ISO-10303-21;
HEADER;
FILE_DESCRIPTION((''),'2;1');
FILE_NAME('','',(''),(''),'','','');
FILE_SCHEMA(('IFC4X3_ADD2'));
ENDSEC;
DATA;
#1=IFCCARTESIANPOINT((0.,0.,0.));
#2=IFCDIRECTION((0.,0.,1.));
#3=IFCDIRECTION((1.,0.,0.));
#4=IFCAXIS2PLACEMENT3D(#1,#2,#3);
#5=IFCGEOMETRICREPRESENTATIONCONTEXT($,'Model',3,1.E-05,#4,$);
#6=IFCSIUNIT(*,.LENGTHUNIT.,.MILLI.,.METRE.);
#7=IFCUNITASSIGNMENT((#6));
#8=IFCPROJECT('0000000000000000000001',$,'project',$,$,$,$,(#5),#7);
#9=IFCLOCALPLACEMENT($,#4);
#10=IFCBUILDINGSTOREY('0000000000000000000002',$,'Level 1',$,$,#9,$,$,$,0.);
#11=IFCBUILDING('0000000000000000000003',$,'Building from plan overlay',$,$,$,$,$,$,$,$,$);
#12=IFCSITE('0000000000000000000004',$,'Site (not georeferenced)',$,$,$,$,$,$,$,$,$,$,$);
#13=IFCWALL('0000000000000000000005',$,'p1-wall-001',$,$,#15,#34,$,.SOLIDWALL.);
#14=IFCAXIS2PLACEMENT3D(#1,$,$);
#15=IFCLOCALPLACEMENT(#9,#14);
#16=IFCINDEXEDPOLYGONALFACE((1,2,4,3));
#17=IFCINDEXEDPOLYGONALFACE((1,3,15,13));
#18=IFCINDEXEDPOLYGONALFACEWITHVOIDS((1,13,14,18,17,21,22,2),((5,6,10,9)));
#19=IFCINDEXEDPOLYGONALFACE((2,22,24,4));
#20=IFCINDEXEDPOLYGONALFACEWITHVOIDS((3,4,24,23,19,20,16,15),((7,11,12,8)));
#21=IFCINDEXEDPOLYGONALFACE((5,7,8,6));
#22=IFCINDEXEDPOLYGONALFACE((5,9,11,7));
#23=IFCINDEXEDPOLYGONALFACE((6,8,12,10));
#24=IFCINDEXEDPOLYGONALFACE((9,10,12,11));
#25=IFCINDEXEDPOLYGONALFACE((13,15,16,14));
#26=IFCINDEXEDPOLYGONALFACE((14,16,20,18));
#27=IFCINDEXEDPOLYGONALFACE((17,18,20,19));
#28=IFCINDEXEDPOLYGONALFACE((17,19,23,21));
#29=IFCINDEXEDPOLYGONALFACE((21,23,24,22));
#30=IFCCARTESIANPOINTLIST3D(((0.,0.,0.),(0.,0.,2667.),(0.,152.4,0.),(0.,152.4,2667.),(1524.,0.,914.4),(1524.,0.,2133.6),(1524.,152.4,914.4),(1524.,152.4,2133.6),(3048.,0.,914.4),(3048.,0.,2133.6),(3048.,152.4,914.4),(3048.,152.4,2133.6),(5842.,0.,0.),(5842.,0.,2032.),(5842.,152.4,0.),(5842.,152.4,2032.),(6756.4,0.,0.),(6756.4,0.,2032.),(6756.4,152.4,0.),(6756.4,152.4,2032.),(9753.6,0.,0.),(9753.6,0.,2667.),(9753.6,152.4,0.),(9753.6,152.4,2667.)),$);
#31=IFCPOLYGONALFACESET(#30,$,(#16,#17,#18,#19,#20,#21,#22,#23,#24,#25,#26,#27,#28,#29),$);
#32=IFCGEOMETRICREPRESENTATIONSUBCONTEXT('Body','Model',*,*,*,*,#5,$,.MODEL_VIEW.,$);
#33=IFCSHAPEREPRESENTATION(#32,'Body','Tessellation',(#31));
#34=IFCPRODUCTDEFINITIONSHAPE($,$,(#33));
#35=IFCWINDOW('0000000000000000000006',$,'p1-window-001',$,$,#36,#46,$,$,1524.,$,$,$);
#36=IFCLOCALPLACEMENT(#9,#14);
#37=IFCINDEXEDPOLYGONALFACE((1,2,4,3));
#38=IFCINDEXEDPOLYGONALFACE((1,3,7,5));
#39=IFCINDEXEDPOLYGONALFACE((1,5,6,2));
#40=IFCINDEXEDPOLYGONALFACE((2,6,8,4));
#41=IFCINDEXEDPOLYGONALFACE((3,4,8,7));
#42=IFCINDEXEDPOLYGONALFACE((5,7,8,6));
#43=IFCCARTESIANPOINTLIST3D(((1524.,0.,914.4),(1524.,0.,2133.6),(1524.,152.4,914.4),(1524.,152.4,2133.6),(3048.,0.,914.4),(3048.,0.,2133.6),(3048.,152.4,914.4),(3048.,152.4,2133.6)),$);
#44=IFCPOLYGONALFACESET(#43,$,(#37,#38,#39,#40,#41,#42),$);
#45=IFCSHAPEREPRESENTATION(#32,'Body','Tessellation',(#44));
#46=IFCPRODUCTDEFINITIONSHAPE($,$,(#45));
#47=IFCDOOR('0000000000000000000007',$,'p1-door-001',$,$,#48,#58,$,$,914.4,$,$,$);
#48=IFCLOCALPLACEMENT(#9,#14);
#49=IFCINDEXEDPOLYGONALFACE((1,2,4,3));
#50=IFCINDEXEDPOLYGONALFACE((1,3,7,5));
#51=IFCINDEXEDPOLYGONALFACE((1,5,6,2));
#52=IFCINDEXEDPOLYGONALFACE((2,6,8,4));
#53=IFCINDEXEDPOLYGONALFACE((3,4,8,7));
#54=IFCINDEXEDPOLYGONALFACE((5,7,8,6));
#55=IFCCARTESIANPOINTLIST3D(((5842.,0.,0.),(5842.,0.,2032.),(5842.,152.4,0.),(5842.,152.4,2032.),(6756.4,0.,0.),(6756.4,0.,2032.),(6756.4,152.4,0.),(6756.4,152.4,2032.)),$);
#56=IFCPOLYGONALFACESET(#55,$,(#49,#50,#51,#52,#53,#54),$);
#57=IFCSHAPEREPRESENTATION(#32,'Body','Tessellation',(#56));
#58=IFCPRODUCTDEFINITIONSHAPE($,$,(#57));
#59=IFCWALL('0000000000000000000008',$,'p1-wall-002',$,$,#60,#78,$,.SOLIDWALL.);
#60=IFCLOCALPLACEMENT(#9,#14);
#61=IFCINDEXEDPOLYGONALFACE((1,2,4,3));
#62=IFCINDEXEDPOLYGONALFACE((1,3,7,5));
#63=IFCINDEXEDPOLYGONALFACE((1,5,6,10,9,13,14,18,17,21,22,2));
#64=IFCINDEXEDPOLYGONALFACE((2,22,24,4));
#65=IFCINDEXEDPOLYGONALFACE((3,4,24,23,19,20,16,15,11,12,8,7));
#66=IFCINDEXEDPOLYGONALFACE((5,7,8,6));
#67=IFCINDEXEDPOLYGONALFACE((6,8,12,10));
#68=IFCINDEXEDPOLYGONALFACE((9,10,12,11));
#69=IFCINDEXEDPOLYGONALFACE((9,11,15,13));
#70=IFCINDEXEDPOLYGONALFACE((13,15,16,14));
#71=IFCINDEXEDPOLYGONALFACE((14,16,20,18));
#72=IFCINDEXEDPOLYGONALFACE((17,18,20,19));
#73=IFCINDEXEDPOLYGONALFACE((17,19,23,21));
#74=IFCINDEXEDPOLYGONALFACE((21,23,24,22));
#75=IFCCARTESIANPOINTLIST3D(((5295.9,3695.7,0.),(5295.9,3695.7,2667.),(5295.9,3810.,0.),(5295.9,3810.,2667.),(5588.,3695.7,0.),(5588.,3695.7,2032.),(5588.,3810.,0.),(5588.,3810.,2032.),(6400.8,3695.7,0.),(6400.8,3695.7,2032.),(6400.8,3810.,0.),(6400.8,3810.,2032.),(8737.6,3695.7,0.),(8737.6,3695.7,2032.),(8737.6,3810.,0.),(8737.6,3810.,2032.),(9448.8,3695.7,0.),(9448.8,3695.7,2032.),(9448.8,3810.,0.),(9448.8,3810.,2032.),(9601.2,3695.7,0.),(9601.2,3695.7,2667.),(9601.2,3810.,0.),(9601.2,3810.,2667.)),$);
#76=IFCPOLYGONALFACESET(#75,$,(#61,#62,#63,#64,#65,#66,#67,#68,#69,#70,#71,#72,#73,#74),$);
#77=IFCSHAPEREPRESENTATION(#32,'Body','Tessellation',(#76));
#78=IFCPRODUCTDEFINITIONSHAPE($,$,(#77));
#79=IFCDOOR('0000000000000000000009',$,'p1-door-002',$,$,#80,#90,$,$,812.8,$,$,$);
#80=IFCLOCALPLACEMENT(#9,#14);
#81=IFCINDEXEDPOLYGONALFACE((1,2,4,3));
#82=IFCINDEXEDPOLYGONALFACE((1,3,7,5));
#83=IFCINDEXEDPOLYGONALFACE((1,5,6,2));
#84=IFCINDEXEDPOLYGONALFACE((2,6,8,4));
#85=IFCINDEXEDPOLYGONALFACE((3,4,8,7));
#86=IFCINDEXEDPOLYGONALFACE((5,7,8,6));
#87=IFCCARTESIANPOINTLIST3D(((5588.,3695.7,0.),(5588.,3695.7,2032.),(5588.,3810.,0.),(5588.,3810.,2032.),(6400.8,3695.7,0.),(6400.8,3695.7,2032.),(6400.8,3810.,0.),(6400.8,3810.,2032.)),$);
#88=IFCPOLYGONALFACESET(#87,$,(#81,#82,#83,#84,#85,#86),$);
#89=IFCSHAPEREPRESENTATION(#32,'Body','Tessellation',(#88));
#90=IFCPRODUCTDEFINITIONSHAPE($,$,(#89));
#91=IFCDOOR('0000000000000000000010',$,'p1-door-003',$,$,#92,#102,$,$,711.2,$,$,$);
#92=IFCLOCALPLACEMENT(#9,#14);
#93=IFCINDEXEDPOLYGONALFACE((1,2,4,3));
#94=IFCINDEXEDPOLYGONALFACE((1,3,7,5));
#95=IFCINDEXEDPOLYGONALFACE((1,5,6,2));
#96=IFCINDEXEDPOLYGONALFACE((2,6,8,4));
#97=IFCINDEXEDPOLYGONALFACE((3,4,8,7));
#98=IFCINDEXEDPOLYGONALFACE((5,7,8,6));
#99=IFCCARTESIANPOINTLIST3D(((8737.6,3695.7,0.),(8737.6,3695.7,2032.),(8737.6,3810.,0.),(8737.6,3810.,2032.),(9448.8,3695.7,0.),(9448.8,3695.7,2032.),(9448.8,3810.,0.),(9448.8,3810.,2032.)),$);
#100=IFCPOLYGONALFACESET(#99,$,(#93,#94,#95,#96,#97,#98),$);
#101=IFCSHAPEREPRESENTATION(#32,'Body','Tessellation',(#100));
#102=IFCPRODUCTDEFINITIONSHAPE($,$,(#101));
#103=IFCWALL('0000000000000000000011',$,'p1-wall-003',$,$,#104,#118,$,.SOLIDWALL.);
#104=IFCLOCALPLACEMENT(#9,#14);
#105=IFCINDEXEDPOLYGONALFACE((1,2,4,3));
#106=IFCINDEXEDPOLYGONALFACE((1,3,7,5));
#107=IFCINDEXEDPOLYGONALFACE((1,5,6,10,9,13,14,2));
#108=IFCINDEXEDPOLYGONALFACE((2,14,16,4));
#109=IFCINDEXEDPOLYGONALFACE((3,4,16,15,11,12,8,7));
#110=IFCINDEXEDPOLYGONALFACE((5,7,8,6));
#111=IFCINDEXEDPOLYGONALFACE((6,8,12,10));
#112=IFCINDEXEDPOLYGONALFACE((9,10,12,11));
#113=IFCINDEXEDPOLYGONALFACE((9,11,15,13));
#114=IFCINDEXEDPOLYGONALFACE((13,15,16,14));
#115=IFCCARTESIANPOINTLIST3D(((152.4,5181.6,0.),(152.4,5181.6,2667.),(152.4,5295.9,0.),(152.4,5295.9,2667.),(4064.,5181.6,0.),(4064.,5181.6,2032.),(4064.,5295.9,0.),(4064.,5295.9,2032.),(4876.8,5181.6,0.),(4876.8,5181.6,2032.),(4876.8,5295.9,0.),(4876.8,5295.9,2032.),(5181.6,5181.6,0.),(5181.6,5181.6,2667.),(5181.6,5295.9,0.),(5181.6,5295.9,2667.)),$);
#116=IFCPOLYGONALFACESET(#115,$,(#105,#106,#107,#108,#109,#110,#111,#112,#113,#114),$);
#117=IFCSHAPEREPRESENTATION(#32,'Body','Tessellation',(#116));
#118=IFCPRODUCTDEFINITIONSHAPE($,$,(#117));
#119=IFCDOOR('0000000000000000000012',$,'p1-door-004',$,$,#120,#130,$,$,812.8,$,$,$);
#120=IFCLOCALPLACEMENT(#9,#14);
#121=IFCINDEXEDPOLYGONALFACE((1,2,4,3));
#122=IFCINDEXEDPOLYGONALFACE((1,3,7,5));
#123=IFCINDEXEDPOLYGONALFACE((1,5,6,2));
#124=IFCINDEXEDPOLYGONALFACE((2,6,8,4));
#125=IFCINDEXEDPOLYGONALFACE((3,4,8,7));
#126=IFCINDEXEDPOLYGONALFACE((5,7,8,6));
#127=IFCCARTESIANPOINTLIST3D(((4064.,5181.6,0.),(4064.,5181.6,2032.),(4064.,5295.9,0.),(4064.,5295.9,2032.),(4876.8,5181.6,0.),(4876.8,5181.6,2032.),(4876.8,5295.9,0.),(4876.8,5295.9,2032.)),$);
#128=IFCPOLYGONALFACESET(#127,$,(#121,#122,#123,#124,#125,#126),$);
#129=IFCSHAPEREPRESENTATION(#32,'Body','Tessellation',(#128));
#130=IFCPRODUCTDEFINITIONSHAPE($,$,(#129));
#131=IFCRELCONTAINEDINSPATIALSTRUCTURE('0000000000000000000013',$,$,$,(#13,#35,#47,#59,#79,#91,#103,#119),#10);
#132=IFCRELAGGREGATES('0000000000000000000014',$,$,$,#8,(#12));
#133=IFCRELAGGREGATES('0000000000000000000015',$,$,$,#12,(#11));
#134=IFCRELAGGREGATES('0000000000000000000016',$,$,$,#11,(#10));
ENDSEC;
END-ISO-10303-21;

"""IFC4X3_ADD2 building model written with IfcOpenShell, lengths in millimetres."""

from ifc_helpers import new_model, si_unit, frame, origin, origin_with_axes, place, context, subcontext, project, spatial, polyline, outline, extrude, element, fill, save


model = new_model("IFC4X3_ADD2")

# Units and contexts
model_context = context("Model", 3, precision=1e-05, world=origin_with_axes())
body_context = subcontext(model_context, "Body", "Model", "MODEL_VIEW")
ifc_project = project(units=[si_unit("LENGTHUNIT", "METRE", prefix="MILLI")], contexts=[model_context])

# Site, building, storey
site = spatial("IfcSite", under=ifc_project, Name="Site (not georeferenced)")
building = spatial("IfcBuilding", under=site, Name="Building from plan overlay")
storey_placement = place(None, origin_with_axes())
storey = spatial("IfcBuildingStorey", under=building, at=storey_placement, Name="Level 1", Elevation=0.0)

# Wall, openings, window, door
wall_1_placement = place(storey_placement, origin_with_axes())
wall_1 = element("IfcWall", 1, at=wall_1_placement, inside=storey, Name="p1-wall-001", PredefinedType="SOLIDWALL", context=body_context, shape_type="SweptSolid", body=[
    extrude(outline(polyline([(0.0, 0.0), (9753.6, 0.0), (9753.6, 152.4), (0.0, 152.4), (0.0, 0.0)])), origin(), (0.0, 0.0, 1.0), 2667.0),
])
opening_1_placement = place(wall_1_placement, origin_with_axes())
opening_1 = element("IfcOpeningElement", 2, at=opening_1_placement, cuts=wall_1, context=body_context, shape_type="SweptSolid", body=[
    extrude(outline(polyline([(1524.0, 0.0), (3048.0, 0.0), (3048.0, 152.4), (1524.0, 152.4), (1524.0, 0.0)])), frame((0.0, 0.0, 914.4)), (0.0, 0.0, 1.0), 1219.2),
])
opening_2_placement = place(wall_1_placement, origin_with_axes())
opening_2 = element("IfcOpeningElement", 3, at=opening_2_placement, cuts=wall_1, context=body_context, shape_type="SweptSolid", body=[
    extrude(outline(polyline([(5842.0, 0.0), (6756.4, 0.0), (6756.4, 152.4), (5842.0, 152.4), (5842.0, 0.0)])), origin(), (0.0, 0.0, 1.0), 2032.0),
])
window_1_placement = place(storey_placement, origin_with_axes())
window_1 = element("IfcWindow", 4, at=window_1_placement, inside=storey, Name="p1-window-001", OverallWidth=1524.0, context=body_context, shape_type="SweptSolid", body=[
    extrude(outline(polyline([(1524.0, 0.0), (3048.0, 0.0), (3048.0, 152.4), (1524.0, 152.4), (1524.0, 0.0)])), frame((0.0, 0.0, 914.4)), (0.0, 0.0, 1.0), 1219.2),
])
fill(opening_1, window_1)
door_1_placement = place(storey_placement, origin_with_axes())
door_1 = element("IfcDoor", 5, at=door_1_placement, inside=storey, Name="p1-door-001", OverallWidth=914.4, context=body_context, shape_type="SweptSolid", body=[
    extrude(outline(polyline([(5842.0, 0.0), (6756.4, 0.0), (6756.4, 152.4), (5842.0, 152.4), (5842.0, 0.0)])), origin(), (0.0, 0.0, 1.0), 2032.0),
])
fill(opening_2, door_1)

# Wall, openings, doors
wall_2_placement = place(storey_placement, origin_with_axes())
wall_2 = element("IfcWall", 6, at=wall_2_placement, inside=storey, Name="p1-wall-002", PredefinedType="SOLIDWALL", context=body_context, shape_type="SweptSolid", body=[
    extrude(outline(polyline([(5295.9, 3695.7), (9601.2, 3695.7), (9601.2, 3810.0), (5295.9, 3810.0), (5295.9, 3695.7)])), origin(), (0.0, 0.0, 1.0), 2667.0),
])
opening_3_placement = place(wall_2_placement, origin_with_axes())
opening_3 = element("IfcOpeningElement", 7, at=opening_3_placement, cuts=wall_2, context=body_context, shape_type="SweptSolid", body=[
    extrude(outline(polyline([(5588.0, 3695.7), (6400.8, 3695.7), (6400.8, 3810.0), (5588.0, 3810.0), (5588.0, 3695.7)])), origin(), (0.0, 0.0, 1.0), 2032.0),
])
opening_4_placement = place(wall_2_placement, origin_with_axes())
opening_4 = element("IfcOpeningElement", 8, at=opening_4_placement, cuts=wall_2, context=body_context, shape_type="SweptSolid", body=[
    extrude(outline(polyline([(8737.6, 3695.7), (9448.8, 3695.7), (9448.8, 3810.0), (8737.6, 3810.0), (8737.6, 3695.7)])), origin(), (0.0, 0.0, 1.0), 2032.0),
])
door_2_placement = place(storey_placement, origin_with_axes())
door_2 = element("IfcDoor", 9, at=door_2_placement, inside=storey, Name="p1-door-002", OverallWidth=812.8, context=body_context, shape_type="SweptSolid", body=[
    extrude(outline(polyline([(5588.0, 3695.7), (6400.8, 3695.7), (6400.8, 3810.0), (5588.0, 3810.0), (5588.0, 3695.7)])), origin(), (0.0, 0.0, 1.0), 2032.0),
])
fill(opening_3, door_2)
door_3_placement = place(storey_placement, origin_with_axes())
door_3 = element("IfcDoor", 10, at=door_3_placement, inside=storey, Name="p1-door-003", OverallWidth=711.2, context=body_context, shape_type="SweptSolid", body=[
    extrude(outline(polyline([(8737.6, 3695.7), (9448.8, 3695.7), (9448.8, 3810.0), (8737.6, 3810.0), (8737.6, 3695.7)])), origin(), (0.0, 0.0, 1.0), 2032.0),
])
fill(opening_4, door_3)

# Wall, opening, door
wall_3_placement = place(storey_placement, origin_with_axes())
wall_3 = element("IfcWall", 11, at=wall_3_placement, inside=storey, Name="p1-wall-003", PredefinedType="SOLIDWALL", context=body_context, shape_type="SweptSolid", body=[
    extrude(outline(polyline([(152.4, 5181.6), (5181.6, 5181.6), (5181.6, 5295.9), (152.4, 5295.9), (152.4, 5181.6)])), origin(), (0.0, 0.0, 1.0), 2667.0),
])
opening_5_placement = place(wall_3_placement, origin_with_axes())
opening_5 = element("IfcOpeningElement", 12, at=opening_5_placement, cuts=wall_3, context=body_context, shape_type="SweptSolid", body=[
    extrude(outline(polyline([(4064.0, 5181.6), (4876.8, 5181.6), (4876.8, 5295.9), (4064.0, 5295.9), (4064.0, 5181.6)])), origin(), (0.0, 0.0, 1.0), 2032.0),
])
door_4_placement = place(storey_placement, origin_with_axes())
door_4 = element("IfcDoor", 13, at=door_4_placement, inside=storey, Name="p1-door-004", OverallWidth=812.8, context=body_context, shape_type="SweptSolid", body=[
    extrude(outline(polyline([(4064.0, 5181.6), (4876.8, 5181.6), (4876.8, 5295.9), (4064.0, 5295.9), (4064.0, 5181.6)])), origin(), (0.0, 0.0, 1.0), 2032.0),
])
fill(opening_5, door_4)

save(model, "model.ifc")
